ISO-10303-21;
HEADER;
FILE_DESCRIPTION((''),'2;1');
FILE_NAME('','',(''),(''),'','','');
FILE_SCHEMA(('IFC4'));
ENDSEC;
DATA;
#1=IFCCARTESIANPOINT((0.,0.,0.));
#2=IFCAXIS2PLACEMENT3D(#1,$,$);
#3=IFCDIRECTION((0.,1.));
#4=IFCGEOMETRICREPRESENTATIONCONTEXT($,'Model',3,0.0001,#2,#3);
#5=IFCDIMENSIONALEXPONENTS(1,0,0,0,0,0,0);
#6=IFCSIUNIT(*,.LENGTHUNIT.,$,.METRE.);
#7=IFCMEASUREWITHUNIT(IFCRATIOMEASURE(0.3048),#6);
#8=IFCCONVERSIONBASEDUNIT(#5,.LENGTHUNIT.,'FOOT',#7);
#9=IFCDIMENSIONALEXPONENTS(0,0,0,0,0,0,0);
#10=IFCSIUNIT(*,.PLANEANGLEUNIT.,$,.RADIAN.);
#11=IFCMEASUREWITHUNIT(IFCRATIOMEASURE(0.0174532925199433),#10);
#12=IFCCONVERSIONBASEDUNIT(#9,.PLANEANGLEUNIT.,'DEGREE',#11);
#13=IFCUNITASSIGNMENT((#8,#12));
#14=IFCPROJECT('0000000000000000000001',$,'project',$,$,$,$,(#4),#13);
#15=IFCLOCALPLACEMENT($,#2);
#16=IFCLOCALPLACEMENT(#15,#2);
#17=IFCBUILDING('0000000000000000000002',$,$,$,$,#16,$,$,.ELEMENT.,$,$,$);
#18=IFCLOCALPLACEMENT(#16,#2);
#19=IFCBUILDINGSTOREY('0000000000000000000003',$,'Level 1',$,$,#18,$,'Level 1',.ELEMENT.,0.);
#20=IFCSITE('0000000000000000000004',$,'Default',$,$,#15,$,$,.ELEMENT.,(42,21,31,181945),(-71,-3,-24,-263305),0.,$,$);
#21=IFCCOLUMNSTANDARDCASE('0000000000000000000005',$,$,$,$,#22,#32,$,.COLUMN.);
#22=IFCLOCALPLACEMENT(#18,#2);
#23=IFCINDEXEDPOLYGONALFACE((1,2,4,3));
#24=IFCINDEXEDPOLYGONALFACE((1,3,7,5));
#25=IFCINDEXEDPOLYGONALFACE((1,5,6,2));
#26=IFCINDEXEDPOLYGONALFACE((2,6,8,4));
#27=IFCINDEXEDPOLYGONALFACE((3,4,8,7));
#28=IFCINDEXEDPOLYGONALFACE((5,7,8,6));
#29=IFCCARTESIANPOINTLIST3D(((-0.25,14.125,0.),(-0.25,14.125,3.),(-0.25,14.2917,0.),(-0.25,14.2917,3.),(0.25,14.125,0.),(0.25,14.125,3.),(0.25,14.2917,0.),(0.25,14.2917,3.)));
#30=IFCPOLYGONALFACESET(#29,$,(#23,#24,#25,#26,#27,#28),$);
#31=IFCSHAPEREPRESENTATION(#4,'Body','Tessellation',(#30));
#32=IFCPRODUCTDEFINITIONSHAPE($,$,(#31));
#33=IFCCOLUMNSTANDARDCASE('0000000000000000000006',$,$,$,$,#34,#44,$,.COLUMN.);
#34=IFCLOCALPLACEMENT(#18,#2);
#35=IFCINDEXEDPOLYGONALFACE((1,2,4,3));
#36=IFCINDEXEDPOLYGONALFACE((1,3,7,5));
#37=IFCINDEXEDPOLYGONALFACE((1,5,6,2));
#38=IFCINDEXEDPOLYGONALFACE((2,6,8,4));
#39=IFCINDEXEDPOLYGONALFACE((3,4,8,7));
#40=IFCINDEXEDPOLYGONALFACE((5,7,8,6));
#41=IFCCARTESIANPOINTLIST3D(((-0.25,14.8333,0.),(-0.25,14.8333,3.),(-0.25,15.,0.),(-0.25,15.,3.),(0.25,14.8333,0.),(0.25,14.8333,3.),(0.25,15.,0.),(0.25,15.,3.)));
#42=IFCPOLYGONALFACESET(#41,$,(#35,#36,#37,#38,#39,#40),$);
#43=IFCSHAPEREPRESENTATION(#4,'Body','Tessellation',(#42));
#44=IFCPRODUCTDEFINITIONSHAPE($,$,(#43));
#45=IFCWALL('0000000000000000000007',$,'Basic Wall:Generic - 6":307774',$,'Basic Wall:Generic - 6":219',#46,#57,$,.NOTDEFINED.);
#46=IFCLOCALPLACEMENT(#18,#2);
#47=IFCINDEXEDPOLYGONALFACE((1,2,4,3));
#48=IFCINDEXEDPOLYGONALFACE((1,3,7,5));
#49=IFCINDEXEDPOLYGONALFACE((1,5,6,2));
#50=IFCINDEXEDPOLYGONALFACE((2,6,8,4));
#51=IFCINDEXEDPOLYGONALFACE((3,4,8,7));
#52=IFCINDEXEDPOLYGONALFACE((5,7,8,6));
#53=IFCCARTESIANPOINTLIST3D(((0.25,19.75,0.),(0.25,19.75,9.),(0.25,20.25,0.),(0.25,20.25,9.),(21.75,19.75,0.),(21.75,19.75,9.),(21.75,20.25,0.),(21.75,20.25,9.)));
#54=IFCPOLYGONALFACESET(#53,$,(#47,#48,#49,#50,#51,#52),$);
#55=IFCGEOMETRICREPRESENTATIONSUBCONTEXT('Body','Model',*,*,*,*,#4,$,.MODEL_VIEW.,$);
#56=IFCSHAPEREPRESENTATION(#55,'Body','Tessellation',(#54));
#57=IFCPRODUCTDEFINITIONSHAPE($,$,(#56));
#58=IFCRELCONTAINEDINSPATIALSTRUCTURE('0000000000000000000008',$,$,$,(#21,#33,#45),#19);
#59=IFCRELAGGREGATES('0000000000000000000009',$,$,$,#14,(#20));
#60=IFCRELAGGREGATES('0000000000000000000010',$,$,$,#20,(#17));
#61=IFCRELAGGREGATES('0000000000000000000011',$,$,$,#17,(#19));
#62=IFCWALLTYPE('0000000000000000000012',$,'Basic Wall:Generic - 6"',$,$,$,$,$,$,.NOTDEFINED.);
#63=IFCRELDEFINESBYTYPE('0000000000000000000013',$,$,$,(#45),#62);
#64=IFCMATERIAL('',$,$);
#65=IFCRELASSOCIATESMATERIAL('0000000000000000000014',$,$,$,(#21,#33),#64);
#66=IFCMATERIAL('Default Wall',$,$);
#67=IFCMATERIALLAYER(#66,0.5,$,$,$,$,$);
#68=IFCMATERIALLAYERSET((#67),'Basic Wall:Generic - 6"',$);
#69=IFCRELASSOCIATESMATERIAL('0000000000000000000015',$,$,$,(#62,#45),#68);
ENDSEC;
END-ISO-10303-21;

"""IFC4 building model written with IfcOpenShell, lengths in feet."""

from ifc_helpers import new_model, entity, si_unit, converted_unit, direction, frame, frame_2d, origin, place, context, subcontext, project, spatial, polyline, rectangle, extrude, clip, bounded_halfspace, material, layer, layer_set, layer_usage, type_object, element, save


model = new_model("IFC4")

# Units and contexts
model_context = context("Model", 3, precision=0.0001, world=origin(), true_north=direction((0.0, 1.0)))
body_context = subcontext(model_context, "Body", "Model", "MODEL_VIEW")
ifc_project = project(units=[converted_unit("LENGTHUNIT", "FOOT", entity("IfcRatioMeasure", 0.3048), si_unit("LENGTHUNIT", "METRE"), dimensions=[1, 0, 0, 0, 0, 0, 0]), converted_unit("PLANEANGLEUNIT", "DEGREE", entity("IfcRatioMeasure", 0.0174532925199433), si_unit("PLANEANGLEUNIT", "RADIAN"), dimensions=[0, 0, 0, 0, 0, 0, 0])], contexts=[model_context])

# Site, building, storey
site_placement = place(None, origin())
site = spatial("IfcSite", under=ifc_project, at=site_placement, Name="Default", CompositionType="ELEMENT", RefLatitude=(42, 21, 31, 181945), RefLongitude=(-71, -3, -24, -263305), RefElevation=0.0)
building_placement = place(site_placement, origin())
building = spatial("IfcBuilding", under=site, at=building_placement, CompositionType="ELEMENT")
storey_placement = place(building_placement, origin())
storey = spatial("IfcBuildingStorey", under=building, at=storey_placement, Name="Level 1", LongName="Level 1", CompositionType="ELEMENT", Elevation=0.0)

# Columns
placement = place(storey_placement, frame((0.0, -0.25, 0.0), z_axis=(0.0, 0.0, 1.0), x_axis=(0.0, 1.0, 0.0)))
ifc_material_1 = material(Name="")
for number, where, z_axis, x_axis in (
    (1, (14.4583, 0.0, 0.0), (0.0, 0.0, 1.0), (1.0, 0.0, 0.0)),
    (2, (15.1667, 0.0, 0.0), (0.0, 0.0, 1.0), (1.0, 0.0, 0.0)),
):
    element("IfcColumnStandardCase", number, at=place(placement, frame(where, z_axis=z_axis, x_axis=x_axis)), inside=storey, material=ifc_material_1, PredefinedType="COLUMN", context=model_context, shape_type="SweptSolid", body=[
        extrude(rectangle(XDim=0.1667, YDim=0.5), origin(), (0.0, 0.0, 1.0), 3.0),
    ])
wall_placement = place(storey_placement, frame((0.25, 20.0, 0.0)))

# Wall
ifc_material_2 = material(Name="Default Wall")
ifc_layer = layer(ifc_material_2, 0.5)
ifc_layer_set = layer_set([ifc_layer], Name="Basic Wall:Generic - 6\"")
ifc_layer_usage = layer_usage(ifc_layer_set, "AXIS2", "NEGATIVE", 0.25)
wall_type = type_object("IfcWallType", Name="Basic Wall:Generic - 6\"", PredefinedType="NOTDEFINED", material=ifc_layer_set)
element("IfcWall", 3, at=wall_placement, inside=storey, type_object=wall_type, material=ifc_layer_usage, Name="Basic Wall:Generic - 6\":307774", ObjectType="Basic Wall:Generic - 6\":219", PredefinedType="NOTDEFINED", context=body_context, shape_type="Clipping", body=[
    clip(clip(extrude(rectangle(XDim=21.5, YDim=0.5, at=frame_2d((10.75, 0.0), x_axis=(-1.0, 0.0))), origin(), (0.0, 0.0, 1.0), 9.0), bounded_halfspace(frame((21.5, -0.25, 9.0), z_axis=(0.0, 0.0, -1.0), x_axis=(0.0, -1.0, 0.0)), True, frame((21.5, -0.25, 9.0)), polyline([(0.0, 0.0), (0.0, 0.5), (-12.0, 0.5), (-12.0, 0.0), (-11.5, 0.0), (0.0, 0.0)]))), bounded_halfspace(frame((0.0, -0.25, 9.0), z_axis=(0.0, 0.0, -1.0), x_axis=(0.0, -1.0, 0.0)), True, frame((0.0, -0.25, 9.0)), polyline([(0.0, 0.0), (9.5, 0.0), (9.5, 0.5), (0.0, 0.5), (0.0, 0.0)]))),
])

save(model, "model.ifc")
